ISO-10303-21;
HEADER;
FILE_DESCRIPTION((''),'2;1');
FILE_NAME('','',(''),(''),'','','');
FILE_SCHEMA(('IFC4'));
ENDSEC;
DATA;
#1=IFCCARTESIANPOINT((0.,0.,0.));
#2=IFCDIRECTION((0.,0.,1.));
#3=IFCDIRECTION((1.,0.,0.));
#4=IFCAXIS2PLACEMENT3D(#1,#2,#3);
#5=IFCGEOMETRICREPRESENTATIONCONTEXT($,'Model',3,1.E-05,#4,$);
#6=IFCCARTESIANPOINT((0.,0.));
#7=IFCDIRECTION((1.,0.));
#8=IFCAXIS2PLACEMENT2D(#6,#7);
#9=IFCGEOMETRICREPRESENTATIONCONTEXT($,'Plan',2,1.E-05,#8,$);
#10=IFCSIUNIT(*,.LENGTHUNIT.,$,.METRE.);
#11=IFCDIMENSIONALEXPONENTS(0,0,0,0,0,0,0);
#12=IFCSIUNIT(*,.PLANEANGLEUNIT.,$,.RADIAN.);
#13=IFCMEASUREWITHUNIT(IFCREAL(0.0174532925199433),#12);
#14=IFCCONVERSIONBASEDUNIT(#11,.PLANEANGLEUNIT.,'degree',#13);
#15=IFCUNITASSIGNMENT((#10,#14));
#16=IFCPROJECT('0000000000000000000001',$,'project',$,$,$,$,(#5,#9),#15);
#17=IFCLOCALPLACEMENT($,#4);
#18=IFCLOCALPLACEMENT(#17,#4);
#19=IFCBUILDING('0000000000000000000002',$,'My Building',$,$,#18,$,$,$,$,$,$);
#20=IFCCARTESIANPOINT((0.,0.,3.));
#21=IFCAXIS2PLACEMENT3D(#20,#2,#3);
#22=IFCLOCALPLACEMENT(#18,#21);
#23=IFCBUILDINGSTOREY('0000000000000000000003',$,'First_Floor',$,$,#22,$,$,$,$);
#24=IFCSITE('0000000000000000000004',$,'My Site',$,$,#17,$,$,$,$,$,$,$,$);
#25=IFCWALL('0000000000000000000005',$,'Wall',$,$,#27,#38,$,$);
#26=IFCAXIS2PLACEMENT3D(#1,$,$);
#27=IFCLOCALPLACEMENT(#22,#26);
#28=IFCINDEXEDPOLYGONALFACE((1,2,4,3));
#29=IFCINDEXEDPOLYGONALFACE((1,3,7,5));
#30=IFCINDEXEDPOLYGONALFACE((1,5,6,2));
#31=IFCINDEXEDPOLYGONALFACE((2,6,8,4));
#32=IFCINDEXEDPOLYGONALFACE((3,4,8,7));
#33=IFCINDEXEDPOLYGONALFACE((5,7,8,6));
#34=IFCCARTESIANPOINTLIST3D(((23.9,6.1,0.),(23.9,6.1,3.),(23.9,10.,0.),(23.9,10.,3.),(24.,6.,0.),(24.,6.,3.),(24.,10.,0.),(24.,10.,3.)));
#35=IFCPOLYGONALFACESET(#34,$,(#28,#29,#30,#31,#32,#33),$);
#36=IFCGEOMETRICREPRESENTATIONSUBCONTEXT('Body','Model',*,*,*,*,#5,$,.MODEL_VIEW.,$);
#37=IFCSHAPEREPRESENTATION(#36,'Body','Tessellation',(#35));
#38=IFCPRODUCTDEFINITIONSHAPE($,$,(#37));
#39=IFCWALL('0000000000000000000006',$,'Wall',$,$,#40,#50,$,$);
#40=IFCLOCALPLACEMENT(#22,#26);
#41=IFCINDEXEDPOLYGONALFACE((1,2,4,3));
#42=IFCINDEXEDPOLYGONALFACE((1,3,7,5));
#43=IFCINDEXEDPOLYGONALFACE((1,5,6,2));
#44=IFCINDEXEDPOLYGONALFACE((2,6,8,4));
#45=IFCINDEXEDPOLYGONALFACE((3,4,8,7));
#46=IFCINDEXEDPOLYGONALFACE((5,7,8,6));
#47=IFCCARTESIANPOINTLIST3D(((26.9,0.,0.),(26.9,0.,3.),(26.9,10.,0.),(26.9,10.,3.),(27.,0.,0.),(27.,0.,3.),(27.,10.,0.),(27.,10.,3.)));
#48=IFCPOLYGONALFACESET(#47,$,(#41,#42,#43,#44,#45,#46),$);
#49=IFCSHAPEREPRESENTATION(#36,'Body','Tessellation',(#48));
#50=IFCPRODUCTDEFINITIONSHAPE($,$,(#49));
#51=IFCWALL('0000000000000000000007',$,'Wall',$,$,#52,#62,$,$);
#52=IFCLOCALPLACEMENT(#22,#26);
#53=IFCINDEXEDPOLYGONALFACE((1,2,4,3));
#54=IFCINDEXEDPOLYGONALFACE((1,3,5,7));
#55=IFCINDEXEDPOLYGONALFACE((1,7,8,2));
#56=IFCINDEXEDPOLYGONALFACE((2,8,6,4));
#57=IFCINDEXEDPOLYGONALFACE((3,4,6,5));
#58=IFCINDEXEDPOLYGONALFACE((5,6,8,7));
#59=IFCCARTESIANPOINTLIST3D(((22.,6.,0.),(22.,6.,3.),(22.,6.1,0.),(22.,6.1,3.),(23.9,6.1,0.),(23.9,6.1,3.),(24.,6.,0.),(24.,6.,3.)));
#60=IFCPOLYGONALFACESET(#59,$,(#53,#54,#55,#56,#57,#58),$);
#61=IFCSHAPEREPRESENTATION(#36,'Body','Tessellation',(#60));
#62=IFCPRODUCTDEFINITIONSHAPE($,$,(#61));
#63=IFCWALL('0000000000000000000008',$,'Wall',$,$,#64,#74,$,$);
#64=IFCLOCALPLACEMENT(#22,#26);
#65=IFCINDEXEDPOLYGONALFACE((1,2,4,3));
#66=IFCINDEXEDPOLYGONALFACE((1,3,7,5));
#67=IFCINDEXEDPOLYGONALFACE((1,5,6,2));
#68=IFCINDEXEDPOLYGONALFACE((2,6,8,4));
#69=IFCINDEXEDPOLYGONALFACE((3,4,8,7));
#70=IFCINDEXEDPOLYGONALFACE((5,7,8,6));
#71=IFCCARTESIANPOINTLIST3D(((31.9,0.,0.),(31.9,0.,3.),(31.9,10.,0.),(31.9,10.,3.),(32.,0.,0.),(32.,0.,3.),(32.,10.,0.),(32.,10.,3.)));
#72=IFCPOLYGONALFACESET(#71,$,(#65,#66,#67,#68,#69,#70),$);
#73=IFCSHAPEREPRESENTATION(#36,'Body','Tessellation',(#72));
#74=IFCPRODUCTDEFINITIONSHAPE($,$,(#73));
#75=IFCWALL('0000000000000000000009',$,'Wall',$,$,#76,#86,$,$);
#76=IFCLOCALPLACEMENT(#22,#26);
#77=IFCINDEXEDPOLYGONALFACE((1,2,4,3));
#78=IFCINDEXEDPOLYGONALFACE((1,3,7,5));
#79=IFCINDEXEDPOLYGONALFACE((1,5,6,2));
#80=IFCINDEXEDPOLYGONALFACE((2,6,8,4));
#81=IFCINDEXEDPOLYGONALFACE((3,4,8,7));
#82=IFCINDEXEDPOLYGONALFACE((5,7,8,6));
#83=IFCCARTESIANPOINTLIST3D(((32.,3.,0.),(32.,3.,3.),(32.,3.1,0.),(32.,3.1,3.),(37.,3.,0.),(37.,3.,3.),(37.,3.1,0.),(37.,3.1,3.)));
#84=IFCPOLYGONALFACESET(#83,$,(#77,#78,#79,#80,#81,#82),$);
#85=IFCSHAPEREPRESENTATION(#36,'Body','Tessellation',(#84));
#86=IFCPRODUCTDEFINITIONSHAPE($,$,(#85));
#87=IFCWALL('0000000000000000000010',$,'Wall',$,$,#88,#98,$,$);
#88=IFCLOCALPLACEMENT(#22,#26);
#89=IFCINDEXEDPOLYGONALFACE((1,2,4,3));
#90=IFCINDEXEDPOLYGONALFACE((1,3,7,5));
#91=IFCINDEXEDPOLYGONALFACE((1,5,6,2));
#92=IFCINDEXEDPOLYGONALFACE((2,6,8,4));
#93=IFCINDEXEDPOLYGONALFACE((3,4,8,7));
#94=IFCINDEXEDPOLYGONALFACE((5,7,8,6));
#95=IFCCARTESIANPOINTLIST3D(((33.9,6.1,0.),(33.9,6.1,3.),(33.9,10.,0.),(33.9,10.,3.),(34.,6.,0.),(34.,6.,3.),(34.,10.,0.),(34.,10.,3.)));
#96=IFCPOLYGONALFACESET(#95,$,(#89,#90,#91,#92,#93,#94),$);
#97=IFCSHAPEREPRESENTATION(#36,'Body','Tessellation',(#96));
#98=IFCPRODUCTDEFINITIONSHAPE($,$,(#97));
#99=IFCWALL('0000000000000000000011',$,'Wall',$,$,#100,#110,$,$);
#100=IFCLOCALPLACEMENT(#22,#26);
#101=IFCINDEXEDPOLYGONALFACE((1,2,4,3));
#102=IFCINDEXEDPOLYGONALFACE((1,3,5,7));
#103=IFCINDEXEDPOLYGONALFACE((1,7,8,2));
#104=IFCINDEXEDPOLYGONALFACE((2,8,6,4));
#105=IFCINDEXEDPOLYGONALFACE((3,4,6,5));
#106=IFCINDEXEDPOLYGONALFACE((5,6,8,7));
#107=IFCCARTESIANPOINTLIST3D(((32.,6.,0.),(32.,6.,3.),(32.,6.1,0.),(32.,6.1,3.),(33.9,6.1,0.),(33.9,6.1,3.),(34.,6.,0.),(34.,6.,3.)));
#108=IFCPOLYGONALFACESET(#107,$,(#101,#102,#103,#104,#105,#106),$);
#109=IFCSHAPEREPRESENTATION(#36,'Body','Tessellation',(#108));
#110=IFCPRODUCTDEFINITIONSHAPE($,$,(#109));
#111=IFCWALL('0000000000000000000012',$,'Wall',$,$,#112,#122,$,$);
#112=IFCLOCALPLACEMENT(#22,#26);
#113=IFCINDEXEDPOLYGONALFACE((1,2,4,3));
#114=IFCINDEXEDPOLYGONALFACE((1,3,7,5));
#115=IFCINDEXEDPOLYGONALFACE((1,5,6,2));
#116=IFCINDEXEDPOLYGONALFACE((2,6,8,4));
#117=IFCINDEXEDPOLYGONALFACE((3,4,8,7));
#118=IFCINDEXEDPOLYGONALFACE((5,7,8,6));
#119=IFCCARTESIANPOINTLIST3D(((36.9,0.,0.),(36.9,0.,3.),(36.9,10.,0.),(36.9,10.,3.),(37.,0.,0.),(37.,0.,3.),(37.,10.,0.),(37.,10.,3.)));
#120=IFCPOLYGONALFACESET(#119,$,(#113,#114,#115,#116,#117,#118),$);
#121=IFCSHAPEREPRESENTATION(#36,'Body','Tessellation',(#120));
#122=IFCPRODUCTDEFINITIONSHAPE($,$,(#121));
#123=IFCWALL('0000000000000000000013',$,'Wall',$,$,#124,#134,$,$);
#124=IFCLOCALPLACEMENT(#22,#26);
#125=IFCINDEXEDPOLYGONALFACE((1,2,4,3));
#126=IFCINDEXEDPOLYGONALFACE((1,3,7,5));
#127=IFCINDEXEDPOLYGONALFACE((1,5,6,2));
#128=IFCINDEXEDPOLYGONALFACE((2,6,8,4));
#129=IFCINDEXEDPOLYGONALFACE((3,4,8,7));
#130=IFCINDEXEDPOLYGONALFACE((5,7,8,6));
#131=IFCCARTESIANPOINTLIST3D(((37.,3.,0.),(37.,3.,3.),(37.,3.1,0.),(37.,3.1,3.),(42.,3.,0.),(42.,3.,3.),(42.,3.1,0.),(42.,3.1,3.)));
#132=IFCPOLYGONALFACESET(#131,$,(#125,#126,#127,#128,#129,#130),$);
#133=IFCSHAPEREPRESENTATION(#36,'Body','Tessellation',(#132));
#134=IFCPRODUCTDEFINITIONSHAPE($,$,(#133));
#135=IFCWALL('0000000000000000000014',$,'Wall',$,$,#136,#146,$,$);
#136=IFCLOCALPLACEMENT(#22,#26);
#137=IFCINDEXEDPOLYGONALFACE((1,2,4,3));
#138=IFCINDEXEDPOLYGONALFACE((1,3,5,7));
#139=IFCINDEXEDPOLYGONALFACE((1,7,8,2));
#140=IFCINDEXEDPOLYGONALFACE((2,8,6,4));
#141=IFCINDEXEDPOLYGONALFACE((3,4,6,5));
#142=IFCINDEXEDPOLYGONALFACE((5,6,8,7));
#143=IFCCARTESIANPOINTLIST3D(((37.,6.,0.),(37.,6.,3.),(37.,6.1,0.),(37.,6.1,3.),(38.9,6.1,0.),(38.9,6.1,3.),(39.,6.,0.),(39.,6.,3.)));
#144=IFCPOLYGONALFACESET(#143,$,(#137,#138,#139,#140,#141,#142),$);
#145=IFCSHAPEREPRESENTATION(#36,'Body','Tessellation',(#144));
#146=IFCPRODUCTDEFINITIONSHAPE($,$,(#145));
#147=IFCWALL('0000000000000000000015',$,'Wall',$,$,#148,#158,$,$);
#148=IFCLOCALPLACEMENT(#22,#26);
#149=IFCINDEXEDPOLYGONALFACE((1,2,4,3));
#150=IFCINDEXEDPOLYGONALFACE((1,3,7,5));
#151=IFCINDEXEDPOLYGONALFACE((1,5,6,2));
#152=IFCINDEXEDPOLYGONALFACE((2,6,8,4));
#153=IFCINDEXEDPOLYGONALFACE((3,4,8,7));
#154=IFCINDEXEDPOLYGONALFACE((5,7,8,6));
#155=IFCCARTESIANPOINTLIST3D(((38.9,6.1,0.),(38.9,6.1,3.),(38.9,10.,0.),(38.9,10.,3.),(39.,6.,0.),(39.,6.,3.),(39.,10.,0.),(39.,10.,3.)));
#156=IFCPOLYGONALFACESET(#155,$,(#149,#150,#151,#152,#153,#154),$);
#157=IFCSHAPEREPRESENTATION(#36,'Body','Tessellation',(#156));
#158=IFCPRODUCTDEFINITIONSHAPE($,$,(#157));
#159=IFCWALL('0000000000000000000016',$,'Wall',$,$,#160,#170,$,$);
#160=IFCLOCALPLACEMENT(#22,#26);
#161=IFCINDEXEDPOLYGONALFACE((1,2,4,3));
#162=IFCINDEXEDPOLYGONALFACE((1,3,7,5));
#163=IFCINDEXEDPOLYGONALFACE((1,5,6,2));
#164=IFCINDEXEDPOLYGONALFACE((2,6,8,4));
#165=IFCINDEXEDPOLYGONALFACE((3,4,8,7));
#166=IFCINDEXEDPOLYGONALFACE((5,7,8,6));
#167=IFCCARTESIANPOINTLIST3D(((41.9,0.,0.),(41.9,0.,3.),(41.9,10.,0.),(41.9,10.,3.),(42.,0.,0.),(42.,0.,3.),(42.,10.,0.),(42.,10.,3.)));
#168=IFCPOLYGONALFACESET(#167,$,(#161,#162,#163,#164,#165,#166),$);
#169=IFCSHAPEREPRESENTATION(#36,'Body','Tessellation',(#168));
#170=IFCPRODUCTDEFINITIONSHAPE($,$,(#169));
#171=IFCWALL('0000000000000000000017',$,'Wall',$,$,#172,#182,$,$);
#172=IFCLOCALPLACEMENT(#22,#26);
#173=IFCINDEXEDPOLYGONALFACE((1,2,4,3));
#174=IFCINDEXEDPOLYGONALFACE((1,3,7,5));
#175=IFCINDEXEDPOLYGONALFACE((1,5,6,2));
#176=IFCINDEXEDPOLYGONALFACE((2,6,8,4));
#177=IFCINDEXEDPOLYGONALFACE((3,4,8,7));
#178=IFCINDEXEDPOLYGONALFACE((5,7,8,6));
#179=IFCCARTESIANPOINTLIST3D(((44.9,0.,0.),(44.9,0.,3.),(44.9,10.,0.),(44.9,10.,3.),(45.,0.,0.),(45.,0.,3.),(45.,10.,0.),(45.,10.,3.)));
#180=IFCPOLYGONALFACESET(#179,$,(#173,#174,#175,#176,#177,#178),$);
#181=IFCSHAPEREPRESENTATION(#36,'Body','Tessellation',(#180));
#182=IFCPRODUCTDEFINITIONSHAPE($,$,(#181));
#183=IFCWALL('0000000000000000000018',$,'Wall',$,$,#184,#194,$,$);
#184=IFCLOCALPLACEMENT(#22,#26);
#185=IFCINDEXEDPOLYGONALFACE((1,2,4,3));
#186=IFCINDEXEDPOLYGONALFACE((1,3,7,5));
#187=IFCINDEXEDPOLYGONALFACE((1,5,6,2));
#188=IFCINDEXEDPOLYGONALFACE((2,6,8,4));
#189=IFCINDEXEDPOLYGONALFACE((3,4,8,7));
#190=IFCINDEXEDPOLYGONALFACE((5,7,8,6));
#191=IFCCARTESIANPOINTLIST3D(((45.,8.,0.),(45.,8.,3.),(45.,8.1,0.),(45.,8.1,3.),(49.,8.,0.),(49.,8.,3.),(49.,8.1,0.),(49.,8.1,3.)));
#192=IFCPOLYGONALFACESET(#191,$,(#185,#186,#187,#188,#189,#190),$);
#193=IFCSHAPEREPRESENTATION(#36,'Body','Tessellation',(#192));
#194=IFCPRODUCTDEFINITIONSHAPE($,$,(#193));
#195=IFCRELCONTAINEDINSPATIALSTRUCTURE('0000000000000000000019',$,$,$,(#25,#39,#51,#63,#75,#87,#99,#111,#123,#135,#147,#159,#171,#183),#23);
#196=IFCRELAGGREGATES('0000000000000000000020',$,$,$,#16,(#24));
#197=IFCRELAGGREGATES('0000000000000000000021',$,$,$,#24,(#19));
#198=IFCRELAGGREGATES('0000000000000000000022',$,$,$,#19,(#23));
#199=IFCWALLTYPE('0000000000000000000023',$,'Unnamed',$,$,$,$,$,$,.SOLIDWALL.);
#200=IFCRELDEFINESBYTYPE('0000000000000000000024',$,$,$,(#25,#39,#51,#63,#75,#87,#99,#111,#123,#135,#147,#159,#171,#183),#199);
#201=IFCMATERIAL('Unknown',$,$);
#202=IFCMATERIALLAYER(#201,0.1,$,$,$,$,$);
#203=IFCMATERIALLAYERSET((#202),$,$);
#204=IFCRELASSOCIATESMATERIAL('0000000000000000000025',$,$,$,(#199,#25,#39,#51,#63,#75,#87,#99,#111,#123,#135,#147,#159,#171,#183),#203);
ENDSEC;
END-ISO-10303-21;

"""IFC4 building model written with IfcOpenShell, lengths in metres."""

from ifc_helpers import new_model, entity, si_unit, converted_unit, frame, origin_with_axes, origin_2d_with_axis, place, context, subcontext, project, spatial, line, indexed_curve, outline, extrude, material, layer, layer_set, layer_usage, type_object, element, save


model = new_model("IFC4")

# Units and contexts
model_context = context("Model", 3, precision=1e-05, world=origin_with_axes())
plan_context = context("Plan", 2, precision=1e-05, world=origin_2d_with_axis())
body_context = subcontext(model_context, "Body", "Model", "MODEL_VIEW")
ifc_project = project(units=[si_unit("LENGTHUNIT", "METRE"), converted_unit("PLANEANGLEUNIT", "degree", entity("IfcReal", 0.0174532925199433), si_unit("PLANEANGLEUNIT", "RADIAN"), dimensions=[0, 0, 0, 0, 0, 0, 0])], contexts=[model_context, plan_context])

# Site, building, storey
site_placement = place(None, origin_with_axes())
site = spatial("IfcSite", under=ifc_project, at=site_placement, Name="My Site")
building_placement = place(site_placement, origin_with_axes())
building = spatial("IfcBuilding", under=site, at=building_placement, Name="My Building")
storey_placement = place(building_placement, frame((0.0, 0.0, 3.0), z_axis=(0.0, 0.0, 1.0), x_axis=(1.0, 0.0, 0.0)))
storey = spatial("IfcBuildingStorey", under=building, at=storey_placement, Name="First_Floor")

# Walls
ifc_material = material(Name="Unknown")
ifc_layer = layer(ifc_material, 0.1)
ifc_layer_set = layer_set([ifc_layer])
ifc_layer_usage_1 = layer_usage(ifc_layer_set, "AXIS2", "POSITIVE", 0.0)
wall_type = type_object("IfcWallType", Name="Unnamed", PredefinedType="SOLIDWALL", material=ifc_layer_set)
wall_1_placement = place(storey_placement, frame((24.0, 6.0, 0.0), z_axis=(0.0, 0.0, 1.0), x_axis=(0.0, 1.0, 0.0)))
element("IfcWall", 1, at=wall_1_placement, inside=storey, type_object=wall_type, material=ifc_layer_usage_1, Name="Wall", context=body_context, shape_type="SweptSolid", body=[
    extrude(outline(indexed_curve([(0.0, 0.0), (0.1, 0.1), (4.0, 0.1), (4.0, 0.0)], segments=[line(1, 2, 3, 4, 1)])), origin_with_axes(), (0.0, 0.0, 1.0), 3.0),
])
ifc_layer_usage_2 = layer_usage(ifc_layer_set, "AXIS2", "POSITIVE", 0.0)
wall_2_placement = place(storey_placement, frame((26.9, 10.0, 0.0), z_axis=(0.0, 0.0, 1.0), x_axis=(0.0, -1.0, 0.0)))
element("IfcWall", 2, at=wall_2_placement, inside=storey, type_object=wall_type, material=ifc_layer_usage_2, Name="Wall", context=body_context, shape_type="SweptSolid", body=[
    extrude(outline(indexed_curve([(0.0, 0.0), (0.0, 0.1), (10.0, 0.1), (10.0, 0.0)], segments=[line(1, 2, 3, 4, 1)])), origin_with_axes(), (0.0, 0.0, 1.0), 3.0),
])
ifc_layer_usage_3 = layer_usage(ifc_layer_set, "AXIS2", "POSITIVE", 0.0)
wall_3_placement = place(storey_placement, frame((22.0, 6.0, 0.0), z_axis=(0.0, 0.0, 1.0), x_axis=(1.0, 0.0, 0.0)))
element("IfcWall", 3, at=wall_3_placement, inside=storey, type_object=wall_type, material=ifc_layer_usage_3, Name="Wall", context=body_context, shape_type="SweptSolid", body=[
    extrude(outline(indexed_curve([(0.0, 0.0), (0.0, 0.1), (1.9, 0.1), (2.0, 0.0)], segments=[line(1, 2, 3, 4, 1)])), origin_with_axes(), (0.0, 0.0, 1.0), 3.0),
])
ifc_layer_usage_4 = layer_usage(ifc_layer_set, "AXIS2", "POSITIVE", 0.0)
wall_4_placement = place(storey_placement, frame((31.9, 10.0, 0.0), z_axis=(0.0, 0.0, 1.0), x_axis=(0.0, -1.0, 0.0)))
element("IfcWall", 4, at=wall_4_placement, inside=storey, type_object=wall_type, material=ifc_layer_usage_4, Name="Wall", context=body_context, shape_type="SweptSolid", body=[
    extrude(outline(indexed_curve([(0.0, 0.0), (0.0, 0.1), (10.0, 0.1), (10.0, 0.0)], segments=[line(1, 2, 3, 4, 1)])), origin_with_axes(), (0.0, 0.0, 1.0), 3.0),
])
ifc_layer_usage_5 = layer_usage(ifc_layer_set, "AXIS2", "POSITIVE", 0.0)
wall_5_placement = place(storey_placement, frame((32.0, 3.0, 0.0), z_axis=(0.0, 0.0, 1.0), x_axis=(1.0, 0.0, 0.0)))
element("IfcWall", 5, at=wall_5_placement, inside=storey, type_object=wall_type, material=ifc_layer_usage_5, Name="Wall", context=body_context, shape_type="SweptSolid", body=[
    extrude(outline(indexed_curve([(0.0, 0.0), (0.0, 0.1), (5.0, 0.1), (5.0, 0.0)], segments=[line(1, 2, 3, 4, 1)])), origin_with_axes(), (0.0, 0.0, 1.0), 3.0),
])
ifc_layer_usage_6 = layer_usage(ifc_layer_set, "AXIS2", "POSITIVE", 0.0)
wall_6_placement = place(storey_placement, frame((34.0, 6.0, 0.0), z_axis=(0.0, 0.0, 1.0), x_axis=(0.0, 1.0, 0.0)))
element("IfcWall", 6, at=wall_6_placement, inside=storey, type_object=wall_type, material=ifc_layer_usage_6, Name="Wall", context=body_context, shape_type="SweptSolid", body=[
    extrude(outline(indexed_curve([(0.0, 0.0), (0.1, 0.1), (4.0, 0.1), (4.0, 0.0)], segments=[line(1, 2, 3, 4, 1)])), origin_with_axes(), (0.0, 0.0, 1.0), 3.0),
])
ifc_layer_usage_7 = layer_usage(ifc_layer_set, "AXIS2", "POSITIVE", 0.0)
wall_7_placement = place(storey_placement, frame((32.0, 6.0, 0.0), z_axis=(0.0, 0.0, 1.0), x_axis=(1.0, 0.0, 0.0)))
element("IfcWall", 7, at=wall_7_placement, inside=storey, type_object=wall_type, material=ifc_layer_usage_7, Name="Wall", context=body_context, shape_type="SweptSolid", body=[
    extrude(outline(indexed_curve([(0.0, 0.0), (0.0, 0.1), (1.9, 0.1), (2.0, 0.0)], segments=[line(1, 2, 3, 4, 1)])), origin_with_axes(), (0.0, 0.0, 1.0), 3.0),
])
ifc_layer_usage_8 = layer_usage(ifc_layer_set, "AXIS2", "POSITIVE", 0.0)
wall_8_placement = place(storey_placement, frame((36.9, 10.0, 0.0), z_axis=(0.0, 0.0, 1.0), x_axis=(0.0, -1.0, 0.0)))
element("IfcWall", 8, at=wall_8_placement, inside=storey, type_object=wall_type, material=ifc_layer_usage_8, Name="Wall", context=body_context, shape_type="SweptSolid", body=[
    extrude(outline(indexed_curve([(0.0, 0.0), (0.0, 0.1), (10.0, 0.1), (10.0, 0.0)], segments=[line(1, 2, 3, 4, 1)])), origin_with_axes(), (0.0, 0.0, 1.0), 3.0),
])
ifc_layer_usage_9 = layer_usage(ifc_layer_set, "AXIS2", "POSITIVE", 0.0)
wall_9_placement = place(storey_placement, frame((37.0, 3.0, 0.0), z_axis=(0.0, 0.0, 1.0), x_axis=(1.0, 0.0, 0.0)))
element("IfcWall", 9, at=wall_9_placement, inside=storey, type_object=wall_type, material=ifc_layer_usage_9, Name="Wall", context=body_context, shape_type="SweptSolid", body=[
    extrude(outline(indexed_curve([(0.0, 0.0), (0.0, 0.1), (5.0, 0.1), (5.0, 0.0)], segments=[line(1, 2, 3, 4, 1)])), origin_with_axes(), (0.0, 0.0, 1.0), 3.0),
])
ifc_layer_usage_10 = layer_usage(ifc_layer_set, "AXIS2", "POSITIVE", 0.0)
wall_10_placement = place(storey_placement, frame((37.0, 6.0, 0.0), z_axis=(0.0, 0.0, 1.0), x_axis=(1.0, 0.0, 0.0)))
element("IfcWall", 10, at=wall_10_placement, inside=storey, type_object=wall_type, material=ifc_layer_usage_10, Name="Wall", context=body_context, shape_type="SweptSolid", body=[
    extrude(outline(indexed_curve([(0.0, 0.0), (0.0, 0.1), (1.9, 0.1), (2.0, 0.0)], segments=[line(1, 2, 3, 4, 1)])), origin_with_axes(), (0.0, 0.0, 1.0), 3.0),
])
ifc_layer_usage_11 = layer_usage(ifc_layer_set, "AXIS2", "POSITIVE", 0.0)
wall_11_placement = place(storey_placement, frame((39.0, 6.0, 0.0), z_axis=(0.0, 0.0, 1.0), x_axis=(0.0, 1.0, 0.0)))
element("IfcWall", 11, at=wall_11_placement, inside=storey, type_object=wall_type, material=ifc_layer_usage_11, Name="Wall", context=body_context, shape_type="SweptSolid", body=[
    extrude(outline(indexed_curve([(0.0, 0.0), (0.1, 0.1), (4.0, 0.1), (4.0, 0.0)], segments=[line(1, 2, 3, 4, 1)])), origin_with_axes(), (0.0, 0.0, 1.0), 3.0),
])
ifc_layer_usage_12 = layer_usage(ifc_layer_set, "AXIS2", "POSITIVE", 0.0)
wall_12_placement = place(storey_placement, frame((41.9, 10.0, 0.0), z_axis=(0.0, 0.0, 1.0), x_axis=(0.0, -1.0, 0.0)))
element("IfcWall", 12, at=wall_12_placement, inside=storey, type_object=wall_type, material=ifc_layer_usage_12, Name="Wall", context=body_context, shape_type="SweptSolid", body=[
    extrude(outline(indexed_curve([(0.0, 0.0), (0.0, 0.1), (10.0, 0.1), (10.0, 0.0)], segments=[line(1, 2, 3, 4, 1)])), origin_with_axes(), (0.0, 0.0, 1.0), 3.0),
])
ifc_layer_usage_13 = layer_usage(ifc_layer_set, "AXIS2", "POSITIVE", 0.0)
wall_13_placement = place(storey_placement, frame((44.9, 10.0, 0.0), z_axis=(0.0, 0.0, 1.0), x_axis=(0.0, -1.0, 0.0)))
element("IfcWall", 13, at=wall_13_placement, inside=storey, type_object=wall_type, material=ifc_layer_usage_13, Name="Wall", context=body_context, shape_type="SweptSolid", body=[
    extrude(outline(indexed_curve([(0.0, 0.0), (0.0, 0.1), (10.0, 0.1), (10.0, 0.0)], segments=[line(1, 2, 3, 4, 1)])), origin_with_axes(), (0.0, 0.0, 1.0), 3.0),
])
ifc_layer_usage_14 = layer_usage(ifc_layer_set, "AXIS2", "POSITIVE", 0.0)
wall_14_placement = place(storey_placement, frame((45.0, 8.0, 0.0), z_axis=(0.0, 0.0, 1.0), x_axis=(1.0, 0.0, 0.0)))
element("IfcWall", 14, at=wall_14_placement, inside=storey, type_object=wall_type, material=ifc_layer_usage_14, Name="Wall", context=body_context, shape_type="SweptSolid", body=[
    extrude(outline(indexed_curve([(0.0, 0.0), (0.0, 0.1), (4.0, 0.1), (4.0, 0.0)], segments=[line(1, 2, 3, 4, 1)])), origin_with_axes(), (0.0, 0.0, 1.0), 3.0),
])

save(model, "model.ifc")
